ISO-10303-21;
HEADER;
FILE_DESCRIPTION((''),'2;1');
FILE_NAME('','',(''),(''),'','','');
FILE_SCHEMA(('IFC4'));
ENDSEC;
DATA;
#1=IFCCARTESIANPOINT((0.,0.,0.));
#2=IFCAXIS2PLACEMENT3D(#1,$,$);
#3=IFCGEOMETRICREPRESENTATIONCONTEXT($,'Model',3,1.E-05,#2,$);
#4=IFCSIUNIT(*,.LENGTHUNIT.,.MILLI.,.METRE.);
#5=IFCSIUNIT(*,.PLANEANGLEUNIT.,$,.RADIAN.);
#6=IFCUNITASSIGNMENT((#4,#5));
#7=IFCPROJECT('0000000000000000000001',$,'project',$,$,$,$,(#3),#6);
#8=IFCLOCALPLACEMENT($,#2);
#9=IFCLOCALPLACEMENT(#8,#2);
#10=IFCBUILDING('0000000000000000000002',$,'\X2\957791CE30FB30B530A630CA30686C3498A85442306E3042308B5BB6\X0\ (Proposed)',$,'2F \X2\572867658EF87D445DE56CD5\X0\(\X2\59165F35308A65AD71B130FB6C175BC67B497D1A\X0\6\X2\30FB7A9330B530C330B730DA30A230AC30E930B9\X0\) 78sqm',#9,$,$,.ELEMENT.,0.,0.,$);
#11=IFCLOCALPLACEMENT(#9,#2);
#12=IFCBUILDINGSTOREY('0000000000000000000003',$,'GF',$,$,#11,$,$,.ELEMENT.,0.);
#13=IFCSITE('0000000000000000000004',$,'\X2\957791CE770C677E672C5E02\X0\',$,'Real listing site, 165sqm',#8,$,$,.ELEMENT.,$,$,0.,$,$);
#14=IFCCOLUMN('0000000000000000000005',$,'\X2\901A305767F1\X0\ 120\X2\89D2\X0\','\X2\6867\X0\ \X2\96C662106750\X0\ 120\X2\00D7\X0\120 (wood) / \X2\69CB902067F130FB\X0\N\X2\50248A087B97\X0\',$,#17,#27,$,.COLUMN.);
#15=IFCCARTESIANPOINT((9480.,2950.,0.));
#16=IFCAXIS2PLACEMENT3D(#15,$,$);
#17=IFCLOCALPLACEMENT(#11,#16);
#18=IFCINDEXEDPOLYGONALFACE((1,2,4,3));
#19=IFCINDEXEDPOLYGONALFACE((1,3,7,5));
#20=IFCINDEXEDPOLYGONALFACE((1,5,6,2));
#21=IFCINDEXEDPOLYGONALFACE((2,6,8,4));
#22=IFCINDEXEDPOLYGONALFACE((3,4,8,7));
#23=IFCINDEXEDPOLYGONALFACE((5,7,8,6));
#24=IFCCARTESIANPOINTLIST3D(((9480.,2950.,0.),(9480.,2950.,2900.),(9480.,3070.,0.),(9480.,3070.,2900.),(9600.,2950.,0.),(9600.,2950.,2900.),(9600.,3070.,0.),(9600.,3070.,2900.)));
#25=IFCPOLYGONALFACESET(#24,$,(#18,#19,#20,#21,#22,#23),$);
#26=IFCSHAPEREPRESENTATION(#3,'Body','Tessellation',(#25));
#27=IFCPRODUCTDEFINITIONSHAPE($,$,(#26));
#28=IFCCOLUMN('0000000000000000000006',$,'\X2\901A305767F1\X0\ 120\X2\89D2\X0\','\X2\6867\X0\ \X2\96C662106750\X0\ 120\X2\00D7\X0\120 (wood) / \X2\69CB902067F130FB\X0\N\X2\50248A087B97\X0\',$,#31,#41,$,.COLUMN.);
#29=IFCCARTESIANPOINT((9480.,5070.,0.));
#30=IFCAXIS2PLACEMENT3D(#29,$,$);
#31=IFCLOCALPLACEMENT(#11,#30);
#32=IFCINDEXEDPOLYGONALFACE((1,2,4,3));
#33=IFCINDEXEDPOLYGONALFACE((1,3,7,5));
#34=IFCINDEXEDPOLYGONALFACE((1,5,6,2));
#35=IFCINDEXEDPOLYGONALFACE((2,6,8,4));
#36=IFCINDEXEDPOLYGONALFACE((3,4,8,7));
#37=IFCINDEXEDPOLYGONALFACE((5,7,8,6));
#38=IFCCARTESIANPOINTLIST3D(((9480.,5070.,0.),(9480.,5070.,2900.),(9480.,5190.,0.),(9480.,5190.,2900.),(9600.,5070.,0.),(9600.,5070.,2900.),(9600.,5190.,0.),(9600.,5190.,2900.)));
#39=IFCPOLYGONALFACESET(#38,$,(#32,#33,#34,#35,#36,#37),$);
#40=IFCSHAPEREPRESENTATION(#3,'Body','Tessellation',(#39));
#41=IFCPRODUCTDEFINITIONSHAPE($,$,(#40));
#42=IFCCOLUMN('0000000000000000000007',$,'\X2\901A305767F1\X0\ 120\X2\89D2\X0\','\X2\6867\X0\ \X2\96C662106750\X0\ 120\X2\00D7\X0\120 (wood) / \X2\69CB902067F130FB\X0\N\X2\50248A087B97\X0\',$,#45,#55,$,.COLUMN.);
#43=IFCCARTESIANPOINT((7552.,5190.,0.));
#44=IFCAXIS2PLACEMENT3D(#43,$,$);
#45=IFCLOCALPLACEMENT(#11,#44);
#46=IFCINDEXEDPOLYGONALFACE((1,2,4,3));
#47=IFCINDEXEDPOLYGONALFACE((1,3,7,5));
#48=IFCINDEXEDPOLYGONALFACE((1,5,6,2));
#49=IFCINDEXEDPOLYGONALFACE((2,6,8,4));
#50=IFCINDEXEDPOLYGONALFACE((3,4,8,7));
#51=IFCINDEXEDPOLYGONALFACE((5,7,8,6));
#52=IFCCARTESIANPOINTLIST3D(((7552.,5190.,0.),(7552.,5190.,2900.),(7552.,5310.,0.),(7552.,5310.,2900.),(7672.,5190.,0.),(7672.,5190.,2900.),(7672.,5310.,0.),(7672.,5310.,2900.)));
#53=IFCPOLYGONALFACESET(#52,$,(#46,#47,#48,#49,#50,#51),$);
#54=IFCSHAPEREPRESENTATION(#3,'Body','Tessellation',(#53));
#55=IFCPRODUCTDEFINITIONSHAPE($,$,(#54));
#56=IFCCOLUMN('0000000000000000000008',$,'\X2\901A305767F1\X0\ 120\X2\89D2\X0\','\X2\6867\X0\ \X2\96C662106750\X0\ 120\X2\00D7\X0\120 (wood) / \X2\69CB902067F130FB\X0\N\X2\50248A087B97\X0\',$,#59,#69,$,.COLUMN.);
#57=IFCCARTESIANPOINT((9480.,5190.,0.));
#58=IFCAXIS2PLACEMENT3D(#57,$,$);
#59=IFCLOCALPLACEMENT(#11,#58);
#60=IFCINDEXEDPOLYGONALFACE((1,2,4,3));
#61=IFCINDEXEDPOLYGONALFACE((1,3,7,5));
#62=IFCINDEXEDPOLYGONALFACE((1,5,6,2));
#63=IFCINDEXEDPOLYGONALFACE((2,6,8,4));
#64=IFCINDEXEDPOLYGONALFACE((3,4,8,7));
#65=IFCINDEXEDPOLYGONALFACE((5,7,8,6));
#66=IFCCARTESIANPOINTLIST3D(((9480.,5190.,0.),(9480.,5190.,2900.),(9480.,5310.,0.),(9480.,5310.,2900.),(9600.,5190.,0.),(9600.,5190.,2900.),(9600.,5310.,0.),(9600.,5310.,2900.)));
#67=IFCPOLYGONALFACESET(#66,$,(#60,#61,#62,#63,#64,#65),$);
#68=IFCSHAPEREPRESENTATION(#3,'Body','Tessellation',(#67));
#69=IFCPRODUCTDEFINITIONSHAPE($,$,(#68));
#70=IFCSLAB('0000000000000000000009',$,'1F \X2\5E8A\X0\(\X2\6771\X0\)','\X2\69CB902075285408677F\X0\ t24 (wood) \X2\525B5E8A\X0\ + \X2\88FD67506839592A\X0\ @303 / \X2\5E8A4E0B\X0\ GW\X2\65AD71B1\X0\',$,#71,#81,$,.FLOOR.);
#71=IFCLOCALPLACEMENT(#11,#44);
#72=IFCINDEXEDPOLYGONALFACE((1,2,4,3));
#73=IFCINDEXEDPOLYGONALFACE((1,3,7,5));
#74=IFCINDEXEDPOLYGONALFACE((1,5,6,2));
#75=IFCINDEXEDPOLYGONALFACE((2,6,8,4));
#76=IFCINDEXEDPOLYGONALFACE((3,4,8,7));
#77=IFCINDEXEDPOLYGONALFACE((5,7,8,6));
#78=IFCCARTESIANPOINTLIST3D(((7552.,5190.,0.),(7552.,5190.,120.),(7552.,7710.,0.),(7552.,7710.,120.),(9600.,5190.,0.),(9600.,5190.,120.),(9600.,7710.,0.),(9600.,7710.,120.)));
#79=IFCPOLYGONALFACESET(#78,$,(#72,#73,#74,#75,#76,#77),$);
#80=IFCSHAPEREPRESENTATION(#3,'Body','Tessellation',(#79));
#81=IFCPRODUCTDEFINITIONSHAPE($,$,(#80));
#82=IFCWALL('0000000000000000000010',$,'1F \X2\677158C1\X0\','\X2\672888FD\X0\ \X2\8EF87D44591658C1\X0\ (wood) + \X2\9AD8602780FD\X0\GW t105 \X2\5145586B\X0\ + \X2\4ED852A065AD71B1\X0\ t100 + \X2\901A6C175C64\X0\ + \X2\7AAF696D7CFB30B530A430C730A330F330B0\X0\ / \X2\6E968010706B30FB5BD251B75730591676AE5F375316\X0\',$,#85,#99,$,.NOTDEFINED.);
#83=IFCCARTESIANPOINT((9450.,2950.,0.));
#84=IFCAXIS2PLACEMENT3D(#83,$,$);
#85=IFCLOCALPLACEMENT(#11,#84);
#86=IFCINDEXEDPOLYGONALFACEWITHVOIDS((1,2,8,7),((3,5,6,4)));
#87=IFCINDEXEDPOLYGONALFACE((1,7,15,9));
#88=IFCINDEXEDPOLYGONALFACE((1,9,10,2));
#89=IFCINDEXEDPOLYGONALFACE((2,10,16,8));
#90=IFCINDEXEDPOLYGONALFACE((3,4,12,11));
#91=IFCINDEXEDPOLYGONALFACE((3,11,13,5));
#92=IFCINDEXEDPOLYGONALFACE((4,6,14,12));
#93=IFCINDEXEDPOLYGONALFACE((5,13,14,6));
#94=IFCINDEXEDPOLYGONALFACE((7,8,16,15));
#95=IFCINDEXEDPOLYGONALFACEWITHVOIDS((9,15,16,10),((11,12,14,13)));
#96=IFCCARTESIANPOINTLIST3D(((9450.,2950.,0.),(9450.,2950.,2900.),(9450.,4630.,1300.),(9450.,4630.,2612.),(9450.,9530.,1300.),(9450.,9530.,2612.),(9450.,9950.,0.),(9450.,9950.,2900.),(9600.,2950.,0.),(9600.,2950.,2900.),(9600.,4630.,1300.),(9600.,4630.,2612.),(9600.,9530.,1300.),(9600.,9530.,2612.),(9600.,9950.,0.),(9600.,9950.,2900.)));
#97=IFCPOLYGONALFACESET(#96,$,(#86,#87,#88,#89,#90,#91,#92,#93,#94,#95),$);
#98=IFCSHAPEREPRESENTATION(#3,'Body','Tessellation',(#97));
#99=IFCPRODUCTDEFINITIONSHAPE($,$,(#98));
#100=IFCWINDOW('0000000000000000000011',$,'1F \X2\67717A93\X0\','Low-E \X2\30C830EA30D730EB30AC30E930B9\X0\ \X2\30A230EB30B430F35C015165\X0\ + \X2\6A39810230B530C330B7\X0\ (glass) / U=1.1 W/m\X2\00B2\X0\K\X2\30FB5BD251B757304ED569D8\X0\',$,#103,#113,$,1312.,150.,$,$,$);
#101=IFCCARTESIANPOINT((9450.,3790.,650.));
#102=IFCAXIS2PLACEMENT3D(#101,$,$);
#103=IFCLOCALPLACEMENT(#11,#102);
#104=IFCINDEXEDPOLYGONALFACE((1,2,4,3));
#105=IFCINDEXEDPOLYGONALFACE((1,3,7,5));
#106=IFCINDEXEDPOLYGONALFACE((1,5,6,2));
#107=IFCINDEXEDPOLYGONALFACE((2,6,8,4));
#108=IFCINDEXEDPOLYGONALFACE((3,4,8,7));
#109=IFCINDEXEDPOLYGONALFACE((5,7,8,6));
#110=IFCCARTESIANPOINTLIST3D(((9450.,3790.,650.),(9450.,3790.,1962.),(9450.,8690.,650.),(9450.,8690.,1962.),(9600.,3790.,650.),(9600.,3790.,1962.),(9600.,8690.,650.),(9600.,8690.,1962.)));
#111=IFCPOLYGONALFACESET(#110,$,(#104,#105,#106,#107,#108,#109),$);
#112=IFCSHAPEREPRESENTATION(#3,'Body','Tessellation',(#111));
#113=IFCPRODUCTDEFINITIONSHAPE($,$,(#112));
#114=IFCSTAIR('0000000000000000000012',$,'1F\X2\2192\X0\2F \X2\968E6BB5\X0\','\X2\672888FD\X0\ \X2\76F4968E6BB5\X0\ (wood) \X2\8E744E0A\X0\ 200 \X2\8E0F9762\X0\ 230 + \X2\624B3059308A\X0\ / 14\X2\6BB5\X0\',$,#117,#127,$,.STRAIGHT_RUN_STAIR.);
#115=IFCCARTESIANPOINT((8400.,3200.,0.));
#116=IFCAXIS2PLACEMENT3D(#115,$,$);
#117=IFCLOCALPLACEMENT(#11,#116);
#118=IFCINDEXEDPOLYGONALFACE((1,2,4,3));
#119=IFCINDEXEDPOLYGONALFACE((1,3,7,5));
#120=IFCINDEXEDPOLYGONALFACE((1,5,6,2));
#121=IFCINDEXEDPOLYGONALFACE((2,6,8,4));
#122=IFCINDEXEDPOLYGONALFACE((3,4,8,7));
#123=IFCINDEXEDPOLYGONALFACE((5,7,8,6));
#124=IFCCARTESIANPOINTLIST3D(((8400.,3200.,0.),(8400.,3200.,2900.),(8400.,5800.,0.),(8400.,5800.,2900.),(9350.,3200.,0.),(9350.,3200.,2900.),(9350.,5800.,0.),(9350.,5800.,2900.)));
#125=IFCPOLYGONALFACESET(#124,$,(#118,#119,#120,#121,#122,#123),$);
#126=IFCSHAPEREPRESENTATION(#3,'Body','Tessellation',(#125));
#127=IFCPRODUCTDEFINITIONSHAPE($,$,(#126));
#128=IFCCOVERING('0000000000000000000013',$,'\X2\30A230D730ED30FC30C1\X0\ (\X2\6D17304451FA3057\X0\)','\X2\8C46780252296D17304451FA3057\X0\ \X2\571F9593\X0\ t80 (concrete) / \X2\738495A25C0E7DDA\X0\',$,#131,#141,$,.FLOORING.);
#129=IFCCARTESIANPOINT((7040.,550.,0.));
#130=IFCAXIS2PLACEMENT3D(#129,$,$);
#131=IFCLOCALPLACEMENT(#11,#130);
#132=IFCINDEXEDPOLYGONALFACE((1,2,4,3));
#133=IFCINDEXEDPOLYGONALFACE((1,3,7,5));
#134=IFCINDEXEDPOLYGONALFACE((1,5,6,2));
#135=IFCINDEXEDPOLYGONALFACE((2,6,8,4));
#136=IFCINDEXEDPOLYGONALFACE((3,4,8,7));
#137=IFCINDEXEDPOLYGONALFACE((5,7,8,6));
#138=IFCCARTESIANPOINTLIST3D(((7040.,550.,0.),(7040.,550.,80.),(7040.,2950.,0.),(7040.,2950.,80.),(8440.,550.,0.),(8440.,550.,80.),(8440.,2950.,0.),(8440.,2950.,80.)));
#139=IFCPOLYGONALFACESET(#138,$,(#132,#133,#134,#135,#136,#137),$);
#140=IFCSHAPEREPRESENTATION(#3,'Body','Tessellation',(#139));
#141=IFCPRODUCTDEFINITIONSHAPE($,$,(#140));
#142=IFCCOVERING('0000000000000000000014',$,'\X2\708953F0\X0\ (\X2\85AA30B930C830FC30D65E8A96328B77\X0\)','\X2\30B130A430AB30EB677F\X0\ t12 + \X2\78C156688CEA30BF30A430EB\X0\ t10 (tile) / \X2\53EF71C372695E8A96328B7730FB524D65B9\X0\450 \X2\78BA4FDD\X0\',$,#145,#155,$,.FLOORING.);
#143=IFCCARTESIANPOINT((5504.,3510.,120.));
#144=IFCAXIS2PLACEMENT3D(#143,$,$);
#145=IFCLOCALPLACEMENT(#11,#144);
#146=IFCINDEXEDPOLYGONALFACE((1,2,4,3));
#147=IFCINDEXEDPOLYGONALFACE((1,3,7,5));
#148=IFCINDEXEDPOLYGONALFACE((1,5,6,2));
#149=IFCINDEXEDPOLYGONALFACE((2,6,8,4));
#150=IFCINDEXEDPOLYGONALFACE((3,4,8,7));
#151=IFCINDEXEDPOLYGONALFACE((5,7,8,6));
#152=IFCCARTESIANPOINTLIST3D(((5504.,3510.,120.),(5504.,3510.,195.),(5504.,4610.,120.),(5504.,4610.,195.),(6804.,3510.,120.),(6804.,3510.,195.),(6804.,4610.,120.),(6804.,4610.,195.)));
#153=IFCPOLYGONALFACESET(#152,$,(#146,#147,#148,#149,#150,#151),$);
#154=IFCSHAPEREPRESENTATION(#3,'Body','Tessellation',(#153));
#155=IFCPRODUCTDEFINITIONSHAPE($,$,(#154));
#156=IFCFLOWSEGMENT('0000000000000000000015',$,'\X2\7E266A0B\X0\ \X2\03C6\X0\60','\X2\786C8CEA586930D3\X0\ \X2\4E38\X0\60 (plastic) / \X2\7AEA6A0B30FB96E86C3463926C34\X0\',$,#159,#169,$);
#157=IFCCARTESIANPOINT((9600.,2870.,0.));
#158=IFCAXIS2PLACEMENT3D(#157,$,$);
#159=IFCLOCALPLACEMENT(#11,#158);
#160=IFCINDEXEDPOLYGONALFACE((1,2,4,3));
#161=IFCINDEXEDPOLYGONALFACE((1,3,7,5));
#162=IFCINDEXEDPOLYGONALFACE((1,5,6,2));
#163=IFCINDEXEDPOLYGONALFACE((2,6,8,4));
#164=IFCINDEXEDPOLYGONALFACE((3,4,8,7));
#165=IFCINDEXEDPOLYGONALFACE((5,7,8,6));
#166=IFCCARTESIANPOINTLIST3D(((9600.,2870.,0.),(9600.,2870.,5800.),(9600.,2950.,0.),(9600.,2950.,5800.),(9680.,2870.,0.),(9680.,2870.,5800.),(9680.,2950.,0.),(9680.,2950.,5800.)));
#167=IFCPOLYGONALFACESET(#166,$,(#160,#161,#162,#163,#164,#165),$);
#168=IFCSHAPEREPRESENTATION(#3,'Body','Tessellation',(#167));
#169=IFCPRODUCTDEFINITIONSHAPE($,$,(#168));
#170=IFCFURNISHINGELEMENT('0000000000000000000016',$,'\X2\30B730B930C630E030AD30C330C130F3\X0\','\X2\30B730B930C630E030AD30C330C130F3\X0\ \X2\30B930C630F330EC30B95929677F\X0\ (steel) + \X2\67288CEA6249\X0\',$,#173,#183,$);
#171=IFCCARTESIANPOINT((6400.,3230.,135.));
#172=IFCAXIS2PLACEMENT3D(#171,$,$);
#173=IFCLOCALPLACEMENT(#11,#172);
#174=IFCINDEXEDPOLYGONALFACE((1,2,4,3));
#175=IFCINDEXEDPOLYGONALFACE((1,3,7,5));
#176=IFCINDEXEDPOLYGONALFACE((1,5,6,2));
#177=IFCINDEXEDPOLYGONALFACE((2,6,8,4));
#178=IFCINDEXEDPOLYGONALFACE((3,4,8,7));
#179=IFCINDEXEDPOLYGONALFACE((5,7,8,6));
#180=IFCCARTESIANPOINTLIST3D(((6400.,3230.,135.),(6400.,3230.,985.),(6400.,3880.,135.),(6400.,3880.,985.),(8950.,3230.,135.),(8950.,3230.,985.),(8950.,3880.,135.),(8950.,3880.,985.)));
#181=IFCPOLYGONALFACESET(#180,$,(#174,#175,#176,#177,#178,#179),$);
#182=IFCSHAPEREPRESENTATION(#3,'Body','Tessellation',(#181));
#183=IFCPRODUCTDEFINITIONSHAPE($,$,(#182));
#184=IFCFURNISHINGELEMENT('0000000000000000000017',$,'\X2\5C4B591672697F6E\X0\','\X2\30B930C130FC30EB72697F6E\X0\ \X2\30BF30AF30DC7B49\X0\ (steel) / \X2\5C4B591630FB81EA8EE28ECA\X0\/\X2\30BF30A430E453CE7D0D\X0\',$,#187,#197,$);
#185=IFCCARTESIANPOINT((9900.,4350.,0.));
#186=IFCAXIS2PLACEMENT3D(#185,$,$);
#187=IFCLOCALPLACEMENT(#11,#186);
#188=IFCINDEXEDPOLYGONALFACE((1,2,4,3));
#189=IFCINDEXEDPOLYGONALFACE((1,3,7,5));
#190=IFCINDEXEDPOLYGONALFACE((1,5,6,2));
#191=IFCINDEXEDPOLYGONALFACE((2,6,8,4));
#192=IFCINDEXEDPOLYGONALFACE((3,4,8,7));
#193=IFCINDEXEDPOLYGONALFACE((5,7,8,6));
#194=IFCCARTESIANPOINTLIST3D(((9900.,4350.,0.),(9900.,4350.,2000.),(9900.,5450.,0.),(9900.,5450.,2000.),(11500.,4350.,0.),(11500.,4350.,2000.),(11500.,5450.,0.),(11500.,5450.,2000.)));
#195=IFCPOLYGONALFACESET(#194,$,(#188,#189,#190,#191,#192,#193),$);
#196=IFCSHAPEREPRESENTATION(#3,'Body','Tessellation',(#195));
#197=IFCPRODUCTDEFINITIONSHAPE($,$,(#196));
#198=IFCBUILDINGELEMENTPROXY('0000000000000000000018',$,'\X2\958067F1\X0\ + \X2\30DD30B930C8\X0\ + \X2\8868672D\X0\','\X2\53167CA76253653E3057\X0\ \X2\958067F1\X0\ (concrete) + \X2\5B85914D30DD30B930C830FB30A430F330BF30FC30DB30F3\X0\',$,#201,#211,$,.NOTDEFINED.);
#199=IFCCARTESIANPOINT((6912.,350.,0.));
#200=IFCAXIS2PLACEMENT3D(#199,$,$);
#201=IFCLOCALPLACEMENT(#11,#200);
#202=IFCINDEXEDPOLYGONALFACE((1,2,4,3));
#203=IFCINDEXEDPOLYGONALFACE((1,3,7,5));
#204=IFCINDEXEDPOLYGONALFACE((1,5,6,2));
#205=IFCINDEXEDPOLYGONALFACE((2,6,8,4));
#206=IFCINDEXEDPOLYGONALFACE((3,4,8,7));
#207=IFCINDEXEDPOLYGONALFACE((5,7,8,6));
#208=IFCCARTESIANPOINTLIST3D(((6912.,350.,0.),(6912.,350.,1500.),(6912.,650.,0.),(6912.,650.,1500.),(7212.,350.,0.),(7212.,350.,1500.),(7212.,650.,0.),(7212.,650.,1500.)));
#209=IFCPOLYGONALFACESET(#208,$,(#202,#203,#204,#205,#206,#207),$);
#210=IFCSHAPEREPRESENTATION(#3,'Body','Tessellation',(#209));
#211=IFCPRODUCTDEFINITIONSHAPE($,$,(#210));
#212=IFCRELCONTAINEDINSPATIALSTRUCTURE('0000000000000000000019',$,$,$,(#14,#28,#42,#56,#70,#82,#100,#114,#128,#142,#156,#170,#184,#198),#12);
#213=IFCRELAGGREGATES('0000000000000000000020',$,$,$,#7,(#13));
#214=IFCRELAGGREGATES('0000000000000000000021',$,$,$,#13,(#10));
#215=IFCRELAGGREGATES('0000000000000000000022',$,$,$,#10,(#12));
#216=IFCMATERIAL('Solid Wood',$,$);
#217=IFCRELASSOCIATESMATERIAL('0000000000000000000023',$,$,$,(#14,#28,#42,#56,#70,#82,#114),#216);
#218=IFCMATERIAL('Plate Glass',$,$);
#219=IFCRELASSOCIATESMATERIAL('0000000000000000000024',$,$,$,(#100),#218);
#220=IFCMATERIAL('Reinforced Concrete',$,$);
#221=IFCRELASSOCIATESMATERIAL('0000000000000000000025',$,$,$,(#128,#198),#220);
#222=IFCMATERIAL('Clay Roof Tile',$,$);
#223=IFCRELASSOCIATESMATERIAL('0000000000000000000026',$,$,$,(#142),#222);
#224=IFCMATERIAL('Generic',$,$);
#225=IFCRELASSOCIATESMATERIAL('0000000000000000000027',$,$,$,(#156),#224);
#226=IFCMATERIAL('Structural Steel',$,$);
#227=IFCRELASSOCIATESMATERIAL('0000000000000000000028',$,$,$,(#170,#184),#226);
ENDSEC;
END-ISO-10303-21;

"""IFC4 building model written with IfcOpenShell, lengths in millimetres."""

from ifc_helpers import new_model, si_unit, frame, frame_2d, origin, place, context, project, spatial, rectangle, extrude, material, element, fill, save


model = new_model("IFC4")

# Units and contexts
model_context = context("Model", 3, precision=1e-05, world=origin())
ifc_project = project(units=[si_unit("LENGTHUNIT", "METRE", prefix="MILLI"), si_unit("PLANEANGLEUNIT", "RADIAN")], contexts=[model_context])

# Site, building, storey
site_placement = place(None, origin())
site = spatial("IfcSite", under=ifc_project, at=site_placement, Name="長野県松本市", ObjectType="Real listing site, 165sqm", CompositionType="ELEMENT", RefElevation=0.0)
building_placement = place(site_placement, origin())
building = spatial("IfcBuilding", under=site, at=building_placement, Name="長野・サウナと水風呂のある家 (Proposed)", ObjectType="2F 在来軸組工法(外張り断熱・気密等級6・窓サッシペアガラス) 78sqm", CompositionType="ELEMENT", ElevationOfRefHeight=0.0, ElevationOfTerrain=0.0)
storey_placement = place(building_placement, origin())
storey = spatial("IfcBuildingStorey", under=building, at=storey_placement, Name="GF", CompositionType="ELEMENT", Elevation=0.0)

# Columns
ifc_material_1 = material(Name="Solid Wood")
column_1_placement = place(storey_placement, frame((9480.0, 2950.0, 0.0)))
element("IfcColumn", 1, at=column_1_placement, inside=storey, material=ifc_material_1, Name="通し柱 120角", Description="桧 集成材 120×120 (wood) / 構造柱・N値計算", PredefinedType="COLUMN", context=model_context, shape_type="SweptSolid", body=[
    extrude(rectangle(XDim=120.0, YDim=120.0, at=frame_2d((60.0, 60.0))), frame((9480.0, 2950.0, 0.0)), (0.0, 0.0, 1.0), 2900.0),
])
column_2_placement = place(storey_placement, frame((9480.0, 5070.0, 0.0)))
element("IfcColumn", 2, at=column_2_placement, inside=storey, material=ifc_material_1, Name="通し柱 120角", Description="桧 集成材 120×120 (wood) / 構造柱・N値計算", PredefinedType="COLUMN", context=model_context, shape_type="SweptSolid", body=[
    extrude(rectangle(XDim=120.0, YDim=120.0, at=frame_2d((60.0, 60.0))), frame((9480.0, 5070.0, 0.0)), (0.0, 0.0, 1.0), 2900.0),
])
column_3_placement = place(storey_placement, frame((7552.0, 5190.0, 0.0)))
element("IfcColumn", 3, at=column_3_placement, inside=storey, material=ifc_material_1, Name="通し柱 120角", Description="桧 集成材 120×120 (wood) / 構造柱・N値計算", PredefinedType="COLUMN", context=model_context, shape_type="SweptSolid", body=[
    extrude(rectangle(XDim=120.0, YDim=120.0, at=frame_2d((60.0, 60.0))), frame((7552.0, 5190.0, 0.0)), (0.0, 0.0, 1.0), 2900.0),
])
column_4_placement = place(storey_placement, frame((9480.0, 5190.0, 0.0)))
element("IfcColumn", 4, at=column_4_placement, inside=storey, material=ifc_material_1, Name="通し柱 120角", Description="桧 集成材 120×120 (wood) / 構造柱・N値計算", PredefinedType="COLUMN", context=model_context, shape_type="SweptSolid", body=[
    extrude(rectangle(XDim=120.0, YDim=120.0, at=frame_2d((60.0, 60.0))), frame((9480.0, 5190.0, 0.0)), (0.0, 0.0, 1.0), 2900.0),
])

# Slab
slab_placement = place(storey_placement, frame((7552.0, 5190.0, 0.0)))
element("IfcSlab", 5, at=slab_placement, inside=storey, material=ifc_material_1, Name="1F 床(東)", Description="構造用合板 t24 (wood) 剛床 + 製材根太 @303 / 床下 GW断熱", PredefinedType="FLOOR", context=model_context, shape_type="SweptSolid", body=[
    extrude(rectangle(XDim=2048.0, YDim=2520.0, at=frame_2d((1024.0, 1260.0))), frame((7552.0, 5190.0, 0.0)), (0.0, 0.0, 1.0), 120.0),
])

# Wall, opening, window
wall_1_placement = place(storey_placement, frame((9450.0, 2950.0, 0.0)))
wall_1 = element("IfcWall", 6, at=wall_1_placement, inside=storey, material=ifc_material_1, Name="1F 東壁", Description="木製 軸組外壁 (wood) + 高性能GW t105 充填 + 付加断熱 t100 + 通気層 + 窯業系サイディング / 準耐火・寒冷地外皮強化", PredefinedType="NOTDEFINED", context=model_context, shape_type="SweptSolid", body=[
    extrude(rectangle(XDim=150.0, YDim=7000.0, at=frame_2d((75.0, 3500.0))), frame((9450.0, 2950.0, 0.0)), (0.0, 0.0, 1.0), 2900.0),
])
opening_placement = place(storey_placement, frame((9450.0, 3790.0, 650.0)))
opening = element("IfcOpeningElement", 7, at=opening_placement, cuts=wall_1, PredefinedType="NOTDEFINED", context=model_context, shape_type="SweptSolid", body=[
    extrude(rectangle(XDim=150.0, YDim=4900.0, at=frame_2d((75.0, 2450.0))), frame((9450.0, 3790.0, 650.0)), (0.0, 0.0, 1.0), 1312.0),
])
ifc_material_2 = material(Name="Plate Glass")
window_placement = place(storey_placement, frame((9450.0, 3790.0, 650.0)))
window = element("IfcWindow", 8, at=window_placement, inside=storey, material=ifc_material_2, Name="1F 東窓", Description="Low-E トリプルガラス アルゴン封入 + 樹脂サッシ (glass) / U=1.1 W/m²K・寒冷地仕様", OverallHeight=1312.0, OverallWidth=150.0, context=model_context, shape_type="SweptSolid", body=[
    extrude(rectangle(XDim=150.0, YDim=4900.0, at=frame_2d((75.0, 2450.0))), frame((9450.0, 3790.0, 650.0)), (0.0, 0.0, 1.0), 1312.0),
])
fill(opening, window)

# Stair
stair_placement = place(storey_placement, frame((8400.0, 3200.0, 0.0)))
element("IfcStair", 9, at=stair_placement, inside=storey, material=ifc_material_1, Name="1F→2F 階段", Description="木製 直階段 (wood) 蹴上 200 踏面 230 + 手すり / 14段", PredefinedType="STRAIGHT_RUN_STAIR", context=model_context, shape_type="SweptSolid", body=[
    extrude(rectangle(XDim=950.0, YDim=2600.0, at=frame_2d((475.0, 1300.0))), frame((8400.0, 3200.0, 0.0)), (0.0, 0.0, 1.0), 2900.0),
])

# Coverings
ifc_material_3 = material(Name="Reinforced Concrete")
covering_1_placement = place(storey_placement, frame((7040.0, 550.0, 0.0)))
element("IfcCovering", 10, at=covering_1_placement, inside=storey, material=ifc_material_3, Name="アプローチ (洗い出し)", Description="豆砂利洗い出し 土間 t80 (concrete) / 玄関導線", PredefinedType="FLOORING", context=model_context, shape_type="SweptSolid", body=[
    extrude(rectangle(XDim=1400.0, YDim=2400.0, at=frame_2d((700.0, 1200.0))), frame((7040.0, 550.0, 0.0)), (0.0, 0.0, 1.0), 80.0),
])
ifc_material_4 = material(Name="Clay Roof Tile")
covering_2_placement = place(storey_placement, frame((5504.0, 3510.0, 120.0)))
element("IfcCovering", 11, at=covering_2_placement, inside=storey, material=ifc_material_4, Name="炉台 (薪ストーブ床防護)", Description="ケイカル板 t12 + 磁器質タイル t10 (tile) / 可燃物床防護・前方450 確保", PredefinedType="FLOORING", context=model_context, shape_type="SweptSolid", body=[
    extrude(rectangle(XDim=1300.0, YDim=1100.0, at=frame_2d((650.0, 550.0))), frame((5504.0, 3510.0, 120.0)), (0.0, 0.0, 1.0), 75.0),
])

# Flow segment
ifc_material_5 = material(Name="Generic")
flow_segment_placement = place(storey_placement, frame((9600.0, 2870.0, 0.0)))
element("IfcFlowSegment", 12, at=flow_segment_placement, inside=storey, material=ifc_material_5, Name="縦樋 φ60", Description="硬質塩ビ 丸60 (plastic) / 竪樋・雨水排水", context=model_context, shape_type="SweptSolid", body=[
    extrude(rectangle(XDim=80.0, YDim=80.0, at=frame_2d((40.0, 40.0))), frame((9600.0, 2870.0, 0.0)), (0.0, 0.0, 1.0), 5800.0),
])

# Furnishing elements
ifc_material_6 = material(Name="Structural Steel")
furnishing_1_placement = place(storey_placement, frame((6400.0, 3230.0, 135.0)))
element("IfcFurnishingElement", 13, at=furnishing_1_placement, inside=storey, material=ifc_material_6, Name="システムキッチン", Description="システムキッチン ステンレス天板 (steel) + 木質扉", context=model_context, shape_type="SweptSolid", body=[
    extrude(rectangle(XDim=2550.0, YDim=650.0, at=frame_2d((1275.0, 325.0))), frame((6400.0, 3230.0, 135.0)), (0.0, 0.0, 1.0), 850.0),
])
furnishing_2_placement = place(storey_placement, frame((9900.0, 4350.0, 0.0)))
element("IfcFurnishingElement", 14, at=furnishing_2_placement, inside=storey, material=ifc_material_6, Name="屋外物置", Description="スチール物置 タクボ等 (steel) / 屋外・自転車/タイヤ収納", context=model_context, shape_type="SweptSolid", body=[
    extrude(rectangle(XDim=1600.0, YDim=1100.0, at=frame_2d((800.0, 550.0))), frame((9900.0, 4350.0, 0.0)), (0.0, 0.0, 1.0), 2000.0),
])

# Building element proxy
proxy_placement = place(storey_placement, frame((6912.0, 350.0, 0.0)))
element("IfcBuildingElementProxy", 15, at=proxy_placement, inside=storey, material=ifc_material_3, Name="門柱 + ポスト + 表札", Description="化粧打放し 門柱 (concrete) + 宅配ポスト・インターホン", PredefinedType="NOTDEFINED", context=model_context, shape_type="SweptSolid", body=[
    extrude(rectangle(XDim=300.0, YDim=300.0, at=frame_2d((150.0, 150.0))), frame((6912.0, 350.0, 0.0)), (0.0, 0.0, 1.0), 1500.0),
])

save(model, "model.ifc")
